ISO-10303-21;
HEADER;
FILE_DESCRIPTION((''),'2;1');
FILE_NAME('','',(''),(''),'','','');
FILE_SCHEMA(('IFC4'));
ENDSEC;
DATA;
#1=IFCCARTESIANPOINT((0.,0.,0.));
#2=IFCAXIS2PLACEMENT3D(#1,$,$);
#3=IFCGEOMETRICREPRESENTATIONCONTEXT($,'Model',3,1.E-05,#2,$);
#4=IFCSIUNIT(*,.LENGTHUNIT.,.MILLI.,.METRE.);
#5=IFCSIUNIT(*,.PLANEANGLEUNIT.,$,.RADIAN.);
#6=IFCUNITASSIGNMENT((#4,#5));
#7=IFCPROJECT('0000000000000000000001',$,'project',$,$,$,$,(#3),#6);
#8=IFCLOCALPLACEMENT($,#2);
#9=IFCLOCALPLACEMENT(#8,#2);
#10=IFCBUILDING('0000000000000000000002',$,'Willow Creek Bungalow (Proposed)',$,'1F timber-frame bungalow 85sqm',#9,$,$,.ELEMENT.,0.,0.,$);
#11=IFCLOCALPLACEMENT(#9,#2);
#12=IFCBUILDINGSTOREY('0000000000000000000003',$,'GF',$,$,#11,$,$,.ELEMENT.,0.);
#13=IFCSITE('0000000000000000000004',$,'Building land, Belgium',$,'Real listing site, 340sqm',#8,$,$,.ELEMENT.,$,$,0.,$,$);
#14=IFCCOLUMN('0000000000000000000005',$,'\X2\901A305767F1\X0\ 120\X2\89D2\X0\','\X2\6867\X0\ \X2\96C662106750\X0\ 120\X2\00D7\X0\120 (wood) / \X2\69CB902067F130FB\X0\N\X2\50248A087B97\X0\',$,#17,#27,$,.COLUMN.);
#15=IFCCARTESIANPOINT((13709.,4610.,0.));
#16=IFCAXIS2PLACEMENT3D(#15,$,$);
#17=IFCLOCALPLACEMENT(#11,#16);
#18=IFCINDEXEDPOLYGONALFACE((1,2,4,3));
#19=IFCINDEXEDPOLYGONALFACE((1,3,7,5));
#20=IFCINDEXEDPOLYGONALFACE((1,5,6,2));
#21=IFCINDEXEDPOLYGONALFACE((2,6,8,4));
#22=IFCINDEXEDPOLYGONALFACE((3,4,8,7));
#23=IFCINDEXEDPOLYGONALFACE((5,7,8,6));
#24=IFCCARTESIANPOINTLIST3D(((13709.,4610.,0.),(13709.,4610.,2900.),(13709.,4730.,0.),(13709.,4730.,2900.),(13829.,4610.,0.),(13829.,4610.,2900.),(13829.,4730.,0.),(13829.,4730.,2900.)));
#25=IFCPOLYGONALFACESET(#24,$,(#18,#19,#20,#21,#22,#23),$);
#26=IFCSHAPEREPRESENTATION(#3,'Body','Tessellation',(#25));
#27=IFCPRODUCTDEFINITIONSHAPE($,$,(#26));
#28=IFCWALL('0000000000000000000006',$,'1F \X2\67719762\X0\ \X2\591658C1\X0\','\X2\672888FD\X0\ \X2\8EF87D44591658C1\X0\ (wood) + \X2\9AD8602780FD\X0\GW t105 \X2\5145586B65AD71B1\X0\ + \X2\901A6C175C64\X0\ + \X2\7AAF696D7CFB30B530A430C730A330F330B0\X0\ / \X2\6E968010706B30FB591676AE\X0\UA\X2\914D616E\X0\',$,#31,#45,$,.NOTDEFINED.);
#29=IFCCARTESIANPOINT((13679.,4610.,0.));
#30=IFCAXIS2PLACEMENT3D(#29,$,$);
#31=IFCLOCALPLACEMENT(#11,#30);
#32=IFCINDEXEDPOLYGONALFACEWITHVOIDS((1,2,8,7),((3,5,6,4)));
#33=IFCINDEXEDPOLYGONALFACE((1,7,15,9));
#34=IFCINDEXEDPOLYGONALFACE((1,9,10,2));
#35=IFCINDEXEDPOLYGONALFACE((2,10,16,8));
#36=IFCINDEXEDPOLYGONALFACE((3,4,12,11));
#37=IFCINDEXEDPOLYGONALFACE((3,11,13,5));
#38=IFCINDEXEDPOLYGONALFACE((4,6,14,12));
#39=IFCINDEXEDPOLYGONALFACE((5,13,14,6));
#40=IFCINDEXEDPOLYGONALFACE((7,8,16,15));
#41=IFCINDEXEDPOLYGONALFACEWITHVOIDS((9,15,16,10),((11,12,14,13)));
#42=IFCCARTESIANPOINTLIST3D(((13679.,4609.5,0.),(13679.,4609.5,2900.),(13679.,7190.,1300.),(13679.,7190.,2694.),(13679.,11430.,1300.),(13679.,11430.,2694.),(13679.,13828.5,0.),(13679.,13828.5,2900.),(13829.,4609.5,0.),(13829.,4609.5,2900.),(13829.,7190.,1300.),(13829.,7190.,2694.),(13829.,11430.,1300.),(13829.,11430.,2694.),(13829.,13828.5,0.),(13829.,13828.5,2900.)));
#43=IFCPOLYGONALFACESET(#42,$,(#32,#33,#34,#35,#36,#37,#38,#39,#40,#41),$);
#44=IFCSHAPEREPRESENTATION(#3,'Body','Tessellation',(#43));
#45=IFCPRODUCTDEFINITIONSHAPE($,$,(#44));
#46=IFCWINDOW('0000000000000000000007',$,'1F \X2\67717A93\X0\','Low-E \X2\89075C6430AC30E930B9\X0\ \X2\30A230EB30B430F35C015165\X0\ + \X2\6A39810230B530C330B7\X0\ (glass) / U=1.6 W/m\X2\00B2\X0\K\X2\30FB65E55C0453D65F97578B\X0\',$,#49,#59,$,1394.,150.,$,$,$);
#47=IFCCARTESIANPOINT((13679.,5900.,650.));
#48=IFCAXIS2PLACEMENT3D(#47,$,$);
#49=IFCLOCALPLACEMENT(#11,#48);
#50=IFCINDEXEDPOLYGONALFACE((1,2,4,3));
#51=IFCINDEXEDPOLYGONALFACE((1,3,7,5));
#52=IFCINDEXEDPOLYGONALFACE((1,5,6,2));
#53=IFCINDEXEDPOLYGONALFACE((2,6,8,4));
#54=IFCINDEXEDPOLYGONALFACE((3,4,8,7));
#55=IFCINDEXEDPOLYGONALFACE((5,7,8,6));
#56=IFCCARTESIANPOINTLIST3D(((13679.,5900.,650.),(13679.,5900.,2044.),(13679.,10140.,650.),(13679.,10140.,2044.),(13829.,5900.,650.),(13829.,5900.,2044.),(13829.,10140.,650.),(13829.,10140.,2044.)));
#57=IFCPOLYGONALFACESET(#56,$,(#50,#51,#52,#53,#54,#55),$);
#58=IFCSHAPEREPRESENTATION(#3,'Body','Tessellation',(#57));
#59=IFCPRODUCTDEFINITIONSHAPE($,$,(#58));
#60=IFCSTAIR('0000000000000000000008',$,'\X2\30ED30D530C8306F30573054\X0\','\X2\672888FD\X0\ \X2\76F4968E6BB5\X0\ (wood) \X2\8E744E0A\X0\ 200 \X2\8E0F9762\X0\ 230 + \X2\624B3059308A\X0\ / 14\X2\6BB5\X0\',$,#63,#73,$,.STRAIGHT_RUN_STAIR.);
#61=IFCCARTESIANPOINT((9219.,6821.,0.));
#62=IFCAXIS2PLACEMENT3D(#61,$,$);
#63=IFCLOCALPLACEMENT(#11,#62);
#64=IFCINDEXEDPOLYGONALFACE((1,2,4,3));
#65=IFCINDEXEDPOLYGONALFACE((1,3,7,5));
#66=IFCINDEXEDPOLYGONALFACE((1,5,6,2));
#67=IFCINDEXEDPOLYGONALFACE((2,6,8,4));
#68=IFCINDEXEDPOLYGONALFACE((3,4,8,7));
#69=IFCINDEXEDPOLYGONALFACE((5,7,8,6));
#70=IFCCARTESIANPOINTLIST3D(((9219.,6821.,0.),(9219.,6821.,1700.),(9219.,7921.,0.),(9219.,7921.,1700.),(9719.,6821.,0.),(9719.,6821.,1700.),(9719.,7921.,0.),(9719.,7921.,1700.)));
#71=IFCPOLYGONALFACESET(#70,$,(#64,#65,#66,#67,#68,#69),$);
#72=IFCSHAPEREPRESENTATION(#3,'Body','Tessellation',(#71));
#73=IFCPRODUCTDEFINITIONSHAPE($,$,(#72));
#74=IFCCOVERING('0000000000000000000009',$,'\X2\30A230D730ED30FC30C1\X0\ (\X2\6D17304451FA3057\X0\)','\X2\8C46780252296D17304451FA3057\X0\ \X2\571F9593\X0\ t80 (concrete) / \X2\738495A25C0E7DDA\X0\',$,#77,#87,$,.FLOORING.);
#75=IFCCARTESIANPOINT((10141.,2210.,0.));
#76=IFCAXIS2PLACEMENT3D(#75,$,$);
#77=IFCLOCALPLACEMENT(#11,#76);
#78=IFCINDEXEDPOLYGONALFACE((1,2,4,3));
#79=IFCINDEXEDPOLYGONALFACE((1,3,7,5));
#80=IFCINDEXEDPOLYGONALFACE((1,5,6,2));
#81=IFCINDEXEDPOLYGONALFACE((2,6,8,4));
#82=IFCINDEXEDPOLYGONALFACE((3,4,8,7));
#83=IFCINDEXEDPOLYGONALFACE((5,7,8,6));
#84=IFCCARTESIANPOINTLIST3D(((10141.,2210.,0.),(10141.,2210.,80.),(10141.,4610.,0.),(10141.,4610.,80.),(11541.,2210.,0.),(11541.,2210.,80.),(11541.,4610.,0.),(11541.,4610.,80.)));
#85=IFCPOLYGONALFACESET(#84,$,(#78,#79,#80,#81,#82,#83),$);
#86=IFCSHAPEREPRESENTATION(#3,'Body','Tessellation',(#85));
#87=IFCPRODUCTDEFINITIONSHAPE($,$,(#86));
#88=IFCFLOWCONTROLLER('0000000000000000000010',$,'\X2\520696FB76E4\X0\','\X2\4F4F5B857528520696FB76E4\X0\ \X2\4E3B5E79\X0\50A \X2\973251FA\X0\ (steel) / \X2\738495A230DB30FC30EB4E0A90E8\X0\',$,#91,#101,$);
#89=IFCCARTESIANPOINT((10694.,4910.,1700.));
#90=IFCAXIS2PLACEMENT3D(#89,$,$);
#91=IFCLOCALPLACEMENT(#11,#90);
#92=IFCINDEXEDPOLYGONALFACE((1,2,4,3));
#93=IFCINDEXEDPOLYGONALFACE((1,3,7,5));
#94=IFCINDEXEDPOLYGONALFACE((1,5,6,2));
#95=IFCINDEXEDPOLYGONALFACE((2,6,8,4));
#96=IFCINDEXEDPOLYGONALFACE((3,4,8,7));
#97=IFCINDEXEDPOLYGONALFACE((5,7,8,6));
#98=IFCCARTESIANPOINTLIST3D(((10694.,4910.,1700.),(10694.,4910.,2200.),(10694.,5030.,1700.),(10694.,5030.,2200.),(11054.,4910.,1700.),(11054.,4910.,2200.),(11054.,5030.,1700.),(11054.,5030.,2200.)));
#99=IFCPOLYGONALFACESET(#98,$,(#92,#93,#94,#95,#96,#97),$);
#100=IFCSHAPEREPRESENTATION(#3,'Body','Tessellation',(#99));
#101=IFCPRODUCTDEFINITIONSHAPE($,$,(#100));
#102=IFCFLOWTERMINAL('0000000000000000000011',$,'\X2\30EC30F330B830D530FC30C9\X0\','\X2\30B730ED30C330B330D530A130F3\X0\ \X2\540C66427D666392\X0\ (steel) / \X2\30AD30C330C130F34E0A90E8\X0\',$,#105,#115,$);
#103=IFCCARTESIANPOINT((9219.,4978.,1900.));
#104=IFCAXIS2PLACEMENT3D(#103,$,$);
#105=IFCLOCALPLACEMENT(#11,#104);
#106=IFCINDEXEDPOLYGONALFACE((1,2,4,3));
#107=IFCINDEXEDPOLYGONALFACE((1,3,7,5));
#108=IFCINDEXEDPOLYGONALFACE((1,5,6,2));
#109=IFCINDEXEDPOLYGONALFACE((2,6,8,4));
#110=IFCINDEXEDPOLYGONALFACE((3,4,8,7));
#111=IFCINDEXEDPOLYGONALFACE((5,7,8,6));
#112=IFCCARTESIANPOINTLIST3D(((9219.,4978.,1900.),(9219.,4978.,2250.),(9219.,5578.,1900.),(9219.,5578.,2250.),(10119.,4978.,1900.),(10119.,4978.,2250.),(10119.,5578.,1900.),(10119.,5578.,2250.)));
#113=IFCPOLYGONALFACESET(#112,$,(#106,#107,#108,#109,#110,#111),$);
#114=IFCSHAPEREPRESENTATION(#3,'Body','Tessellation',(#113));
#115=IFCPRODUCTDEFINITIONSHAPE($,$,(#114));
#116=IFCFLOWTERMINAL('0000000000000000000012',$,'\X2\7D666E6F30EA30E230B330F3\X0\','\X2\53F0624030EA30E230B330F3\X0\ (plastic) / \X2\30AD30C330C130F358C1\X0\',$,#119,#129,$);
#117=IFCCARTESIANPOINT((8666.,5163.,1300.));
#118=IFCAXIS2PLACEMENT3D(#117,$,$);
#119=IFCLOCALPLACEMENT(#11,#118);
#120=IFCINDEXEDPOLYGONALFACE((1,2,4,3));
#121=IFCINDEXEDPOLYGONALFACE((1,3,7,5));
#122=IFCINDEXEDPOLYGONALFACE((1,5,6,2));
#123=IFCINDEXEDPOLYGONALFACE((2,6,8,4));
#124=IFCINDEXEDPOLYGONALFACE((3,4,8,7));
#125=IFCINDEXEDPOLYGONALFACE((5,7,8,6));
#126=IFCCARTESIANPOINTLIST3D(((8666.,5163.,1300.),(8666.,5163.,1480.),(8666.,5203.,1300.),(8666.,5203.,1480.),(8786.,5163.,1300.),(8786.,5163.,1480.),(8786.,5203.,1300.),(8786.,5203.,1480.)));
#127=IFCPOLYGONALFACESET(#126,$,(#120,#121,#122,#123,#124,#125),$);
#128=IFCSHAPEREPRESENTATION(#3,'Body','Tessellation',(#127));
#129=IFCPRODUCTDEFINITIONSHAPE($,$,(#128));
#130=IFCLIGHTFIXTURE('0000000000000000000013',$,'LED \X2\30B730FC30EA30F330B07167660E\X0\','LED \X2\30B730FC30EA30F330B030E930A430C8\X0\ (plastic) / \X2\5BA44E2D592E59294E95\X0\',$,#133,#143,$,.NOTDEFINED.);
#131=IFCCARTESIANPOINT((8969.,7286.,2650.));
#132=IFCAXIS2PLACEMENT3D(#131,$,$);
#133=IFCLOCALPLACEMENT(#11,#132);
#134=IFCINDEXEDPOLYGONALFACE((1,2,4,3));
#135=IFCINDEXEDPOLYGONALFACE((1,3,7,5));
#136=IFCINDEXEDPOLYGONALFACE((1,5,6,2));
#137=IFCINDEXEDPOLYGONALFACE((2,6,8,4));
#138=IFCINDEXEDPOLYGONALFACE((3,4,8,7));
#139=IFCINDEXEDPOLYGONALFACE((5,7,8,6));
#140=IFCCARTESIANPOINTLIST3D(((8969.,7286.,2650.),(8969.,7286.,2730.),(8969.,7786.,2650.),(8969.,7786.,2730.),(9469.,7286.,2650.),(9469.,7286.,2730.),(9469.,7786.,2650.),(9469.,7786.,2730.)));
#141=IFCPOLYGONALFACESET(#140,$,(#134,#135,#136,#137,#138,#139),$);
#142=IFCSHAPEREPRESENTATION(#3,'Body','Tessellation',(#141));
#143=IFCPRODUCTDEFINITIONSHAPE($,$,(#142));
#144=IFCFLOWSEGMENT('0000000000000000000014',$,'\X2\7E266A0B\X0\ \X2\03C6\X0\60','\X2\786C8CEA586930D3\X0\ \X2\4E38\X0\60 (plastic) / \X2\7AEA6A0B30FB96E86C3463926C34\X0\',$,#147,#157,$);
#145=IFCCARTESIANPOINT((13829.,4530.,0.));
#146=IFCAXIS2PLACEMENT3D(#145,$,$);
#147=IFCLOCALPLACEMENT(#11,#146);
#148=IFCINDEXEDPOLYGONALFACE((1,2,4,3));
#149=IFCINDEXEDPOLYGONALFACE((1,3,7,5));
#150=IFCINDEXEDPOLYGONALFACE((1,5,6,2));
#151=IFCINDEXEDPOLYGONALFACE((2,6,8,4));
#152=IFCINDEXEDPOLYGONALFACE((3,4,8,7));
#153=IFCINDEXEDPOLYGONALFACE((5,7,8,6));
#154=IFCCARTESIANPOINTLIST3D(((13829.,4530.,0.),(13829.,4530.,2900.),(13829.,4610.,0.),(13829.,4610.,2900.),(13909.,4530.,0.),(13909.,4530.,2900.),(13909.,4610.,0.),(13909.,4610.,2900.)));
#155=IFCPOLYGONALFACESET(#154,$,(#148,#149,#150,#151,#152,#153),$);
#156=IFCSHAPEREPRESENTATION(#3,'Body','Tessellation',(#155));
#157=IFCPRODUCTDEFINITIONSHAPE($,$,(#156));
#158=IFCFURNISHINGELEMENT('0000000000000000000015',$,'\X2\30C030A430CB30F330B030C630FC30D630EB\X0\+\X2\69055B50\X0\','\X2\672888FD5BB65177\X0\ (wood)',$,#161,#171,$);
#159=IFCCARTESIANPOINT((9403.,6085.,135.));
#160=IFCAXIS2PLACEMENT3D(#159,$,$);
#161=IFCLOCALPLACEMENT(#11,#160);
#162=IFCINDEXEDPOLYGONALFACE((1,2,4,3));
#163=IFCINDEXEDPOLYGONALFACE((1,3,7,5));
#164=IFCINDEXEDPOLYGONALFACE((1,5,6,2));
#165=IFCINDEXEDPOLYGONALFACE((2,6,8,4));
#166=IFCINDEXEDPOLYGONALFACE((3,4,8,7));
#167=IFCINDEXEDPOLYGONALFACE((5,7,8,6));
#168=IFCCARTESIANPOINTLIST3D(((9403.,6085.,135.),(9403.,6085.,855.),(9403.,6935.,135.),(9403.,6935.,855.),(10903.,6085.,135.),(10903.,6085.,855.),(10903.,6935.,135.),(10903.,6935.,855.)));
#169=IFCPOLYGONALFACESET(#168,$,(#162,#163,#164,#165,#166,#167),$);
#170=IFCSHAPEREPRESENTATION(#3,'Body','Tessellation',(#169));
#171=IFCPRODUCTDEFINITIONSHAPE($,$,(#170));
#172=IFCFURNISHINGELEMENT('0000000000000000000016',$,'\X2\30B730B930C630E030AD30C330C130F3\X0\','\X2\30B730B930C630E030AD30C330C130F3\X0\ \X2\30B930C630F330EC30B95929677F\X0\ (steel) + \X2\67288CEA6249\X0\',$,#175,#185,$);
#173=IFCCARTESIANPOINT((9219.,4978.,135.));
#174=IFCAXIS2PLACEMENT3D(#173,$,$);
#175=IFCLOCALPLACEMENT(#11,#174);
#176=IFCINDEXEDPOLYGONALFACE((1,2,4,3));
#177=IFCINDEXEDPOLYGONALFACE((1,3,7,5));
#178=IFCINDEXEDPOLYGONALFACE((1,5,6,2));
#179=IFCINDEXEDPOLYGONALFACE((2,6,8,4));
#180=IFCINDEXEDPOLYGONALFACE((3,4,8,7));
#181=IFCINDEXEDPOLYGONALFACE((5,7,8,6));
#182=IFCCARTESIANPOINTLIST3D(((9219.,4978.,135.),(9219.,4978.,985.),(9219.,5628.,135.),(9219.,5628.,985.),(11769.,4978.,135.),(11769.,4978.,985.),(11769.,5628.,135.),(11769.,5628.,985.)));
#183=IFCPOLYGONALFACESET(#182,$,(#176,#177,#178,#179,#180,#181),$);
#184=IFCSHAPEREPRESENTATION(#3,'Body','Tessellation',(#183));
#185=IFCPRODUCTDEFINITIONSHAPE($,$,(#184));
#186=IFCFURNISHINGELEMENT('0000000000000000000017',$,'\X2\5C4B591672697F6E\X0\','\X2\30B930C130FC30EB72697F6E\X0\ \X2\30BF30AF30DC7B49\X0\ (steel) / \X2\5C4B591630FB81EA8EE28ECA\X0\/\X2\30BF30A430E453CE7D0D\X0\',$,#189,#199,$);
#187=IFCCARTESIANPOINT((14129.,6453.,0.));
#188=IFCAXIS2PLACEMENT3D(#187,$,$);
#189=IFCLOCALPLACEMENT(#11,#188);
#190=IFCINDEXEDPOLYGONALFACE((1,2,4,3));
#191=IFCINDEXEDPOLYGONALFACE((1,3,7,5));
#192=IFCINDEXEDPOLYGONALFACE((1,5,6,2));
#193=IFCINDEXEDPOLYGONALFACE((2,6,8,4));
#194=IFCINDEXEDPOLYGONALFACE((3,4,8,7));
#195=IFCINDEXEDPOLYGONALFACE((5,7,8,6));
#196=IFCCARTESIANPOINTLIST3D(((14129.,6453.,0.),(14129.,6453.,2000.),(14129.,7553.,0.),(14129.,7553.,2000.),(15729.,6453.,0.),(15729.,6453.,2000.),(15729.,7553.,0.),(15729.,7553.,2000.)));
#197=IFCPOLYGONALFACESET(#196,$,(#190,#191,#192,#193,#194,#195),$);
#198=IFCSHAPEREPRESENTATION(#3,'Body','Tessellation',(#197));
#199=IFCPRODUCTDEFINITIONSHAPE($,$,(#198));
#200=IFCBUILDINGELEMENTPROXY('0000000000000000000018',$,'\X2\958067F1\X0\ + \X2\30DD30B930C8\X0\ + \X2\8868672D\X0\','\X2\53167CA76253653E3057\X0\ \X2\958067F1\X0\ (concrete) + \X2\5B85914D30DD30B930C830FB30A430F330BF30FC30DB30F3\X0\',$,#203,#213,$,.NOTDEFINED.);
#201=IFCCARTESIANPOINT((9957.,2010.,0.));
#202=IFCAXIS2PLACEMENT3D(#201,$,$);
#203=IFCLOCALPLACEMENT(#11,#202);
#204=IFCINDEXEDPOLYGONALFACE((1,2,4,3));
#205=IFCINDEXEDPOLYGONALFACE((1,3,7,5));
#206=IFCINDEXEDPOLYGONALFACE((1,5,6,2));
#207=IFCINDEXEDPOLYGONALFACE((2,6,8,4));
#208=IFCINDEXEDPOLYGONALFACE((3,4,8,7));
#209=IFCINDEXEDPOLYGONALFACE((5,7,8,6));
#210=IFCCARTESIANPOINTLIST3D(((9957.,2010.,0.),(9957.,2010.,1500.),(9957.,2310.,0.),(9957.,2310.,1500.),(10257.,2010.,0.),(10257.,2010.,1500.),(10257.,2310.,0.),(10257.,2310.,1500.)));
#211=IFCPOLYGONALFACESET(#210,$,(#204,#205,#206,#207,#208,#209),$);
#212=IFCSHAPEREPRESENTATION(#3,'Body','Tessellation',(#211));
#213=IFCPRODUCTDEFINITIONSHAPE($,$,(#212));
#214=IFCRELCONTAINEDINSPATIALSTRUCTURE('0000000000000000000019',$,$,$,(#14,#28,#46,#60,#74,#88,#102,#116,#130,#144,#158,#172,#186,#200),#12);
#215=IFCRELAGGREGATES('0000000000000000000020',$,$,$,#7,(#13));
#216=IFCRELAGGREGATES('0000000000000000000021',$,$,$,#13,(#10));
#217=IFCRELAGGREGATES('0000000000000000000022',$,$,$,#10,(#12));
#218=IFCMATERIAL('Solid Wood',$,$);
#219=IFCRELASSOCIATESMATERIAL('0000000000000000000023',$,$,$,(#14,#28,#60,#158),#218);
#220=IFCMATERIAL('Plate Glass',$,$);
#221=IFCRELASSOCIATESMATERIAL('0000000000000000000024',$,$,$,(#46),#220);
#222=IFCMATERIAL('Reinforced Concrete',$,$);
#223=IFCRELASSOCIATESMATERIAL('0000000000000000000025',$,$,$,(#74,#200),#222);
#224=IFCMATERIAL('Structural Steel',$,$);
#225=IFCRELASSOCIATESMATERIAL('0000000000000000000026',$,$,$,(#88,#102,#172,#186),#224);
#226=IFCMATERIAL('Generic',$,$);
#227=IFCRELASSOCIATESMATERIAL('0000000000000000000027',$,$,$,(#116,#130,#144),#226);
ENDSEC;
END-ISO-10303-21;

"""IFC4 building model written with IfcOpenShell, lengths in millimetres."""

from ifc_helpers import new_model, si_unit, frame, frame_2d, origin, place, context, project, spatial, rectangle, extrude, material, element, fill, save


model = new_model("IFC4")

# Units and contexts
model_context = context("Model", 3, precision=1e-05, world=origin())
ifc_project = project(units=[si_unit("LENGTHUNIT", "METRE", prefix="MILLI"), si_unit("PLANEANGLEUNIT", "RADIAN")], contexts=[model_context])

# Site, building, storey
site_placement = place(None, origin())
site = spatial("IfcSite", under=ifc_project, at=site_placement, Name="Building land, Belgium", ObjectType="Real listing site, 340sqm", CompositionType="ELEMENT", RefElevation=0.0)
building_placement = place(site_placement, origin())
building = spatial("IfcBuilding", under=site, at=building_placement, Name="Willow Creek Bungalow (Proposed)", ObjectType="1F timber-frame bungalow 85sqm", CompositionType="ELEMENT", ElevationOfRefHeight=0.0, ElevationOfTerrain=0.0)
storey_placement = place(building_placement, origin())
storey = spatial("IfcBuildingStorey", under=building, at=storey_placement, Name="GF", CompositionType="ELEMENT", Elevation=0.0)

# Column
ifc_material_1 = material(Name="Solid Wood")
column_1_placement = place(storey_placement, frame((13709.0, 4610.0, 0.0)))
element("IfcColumn", 1, at=column_1_placement, inside=storey, material=ifc_material_1, Name="通し柱 120角", Description="桧 集成材 120×120 (wood) / 構造柱・N値計算", PredefinedType="COLUMN", context=model_context, shape_type="SweptSolid", body=[
    extrude(rectangle(XDim=120.0, YDim=120.0, at=frame_2d((60.0, 60.0))), frame((13709.0, 4610.0, 0.0)), (0.0, 0.0, 1.0), 2900.0),
])

# Wall, opening, window
wall_1_placement = place(storey_placement, frame((13679.0, 4610.0, 0.0)))
wall_1 = element("IfcWall", 2, at=wall_1_placement, inside=storey, material=ifc_material_1, Name="1F 東面 外壁", Description="木製 軸組外壁 (wood) + 高性能GW t105 充填断熱 + 通気層 + 窯業系サイディング / 準耐火・外皮UA配慮", PredefinedType="NOTDEFINED", context=model_context, shape_type="SweptSolid", body=[
    extrude(rectangle(XDim=150.0, YDim=9219.0, at=frame_2d((75.0, 4609.0))), frame((13679.0, 4610.0, 0.0)), (0.0, 0.0, 1.0), 2900.0),
])
opening_placement = place(storey_placement, frame((13679.0, 5900.0, 650.0)))
opening = element("IfcOpeningElement", 3, at=opening_placement, cuts=wall_1, PredefinedType="NOTDEFINED", context=model_context, shape_type="SweptSolid", body=[
    extrude(rectangle(XDim=150.0, YDim=4240.0, at=frame_2d((75.0, 2120.0))), frame((13679.0, 5900.0, 650.0)), (0.0, 0.0, 1.0), 1394.0),
])
ifc_material_2 = material(Name="Plate Glass")
window_placement = place(storey_placement, frame((13679.0, 5900.0, 650.0)))
window = element("IfcWindow", 4, at=window_placement, inside=storey, material=ifc_material_2, Name="1F 東窓", Description="Low-E 複層ガラス アルゴン封入 + 樹脂サッシ (glass) / U=1.6 W/m²K・日射取得型", OverallHeight=1394.0, OverallWidth=150.0, context=model_context, shape_type="SweptSolid", body=[
    extrude(rectangle(XDim=150.0, YDim=4240.0, at=frame_2d((75.0, 2120.0))), frame((13679.0, 5900.0, 650.0)), (0.0, 0.0, 1.0), 1394.0),
])
fill(opening, window)

# Stair
stair_placement = place(storey_placement, frame((9219.0, 6821.0, 0.0)))
element("IfcStair", 5, at=stair_placement, inside=storey, material=ifc_material_1, Name="ロフトはしご", Description="木製 直階段 (wood) 蹴上 200 踏面 230 + 手すり / 14段", PredefinedType="STRAIGHT_RUN_STAIR", context=model_context, shape_type="SweptSolid", body=[
    extrude(rectangle(XDim=500.0, YDim=1100.0, at=frame_2d((250.0, 550.0))), frame((9219.0, 6821.0, 0.0)), (0.0, 0.0, 1.0), 1700.0),
])

# Covering
ifc_material_3 = material(Name="Reinforced Concrete")
covering_placement = place(storey_placement, frame((10141.0, 2210.0, 0.0)))
element("IfcCovering", 6, at=covering_placement, inside=storey, material=ifc_material_3, Name="アプローチ (洗い出し)", Description="豆砂利洗い出し 土間 t80 (concrete) / 玄関導線", PredefinedType="FLOORING", context=model_context, shape_type="SweptSolid", body=[
    extrude(rectangle(XDim=1400.0, YDim=2400.0, at=frame_2d((700.0, 1200.0))), frame((10141.0, 2210.0, 0.0)), (0.0, 0.0, 1.0), 80.0),
])

# Flow controller
ifc_material_4 = material(Name="Structural Steel")
flow_controller_placement = place(storey_placement, frame((10694.0, 4910.0, 1700.0)))
element("IfcFlowController", 7, at=flow_controller_placement, inside=storey, material=ifc_material_4, Name="分電盤", Description="住宅用分電盤 主幹50A 露出 (steel) / 玄関ホール上部", context=model_context, shape_type="SweptSolid", body=[
    extrude(rectangle(XDim=360.0, YDim=120.0, at=frame_2d((180.0, 60.0))), frame((10694.0, 4910.0, 1700.0)), (0.0, 0.0, 1.0), 500.0),
])

# Flow terminals
flow_terminal_1_placement = place(storey_placement, frame((9219.0, 4978.0, 1900.0)))
element("IfcFlowTerminal", 8, at=flow_terminal_1_placement, inside=storey, material=ifc_material_4, Name="レンジフード", Description="シロッコファン 同時給排 (steel) / キッチン上部", context=model_context, shape_type="SweptSolid", body=[
    extrude(rectangle(XDim=900.0, YDim=600.0, at=frame_2d((450.0, 300.0))), frame((9219.0, 4978.0, 1900.0)), (0.0, 0.0, 1.0), 350.0),
])
ifc_material_5 = material(Name="Generic")
flow_terminal_2_placement = place(storey_placement, frame((8666.0, 5163.0, 1300.0)))
element("IfcFlowTerminal", 9, at=flow_terminal_2_placement, inside=storey, material=ifc_material_5, Name="給湯リモコン", Description="台所リモコン (plastic) / キッチン壁", context=model_context, shape_type="SweptSolid", body=[
    extrude(rectangle(XDim=120.0, YDim=40.0, at=frame_2d((60.0, 20.0))), frame((8666.0, 5163.0, 1300.0)), (0.0, 0.0, 1.0), 180.0),
])

# Light fixture
light_fixture_placement = place(storey_placement, frame((8969.0, 7286.0, 2650.0)))
element("IfcLightFixture", 10, at=light_fixture_placement, inside=storey, material=ifc_material_5, Name="LED シーリング照明", Description="LED シーリングライト (plastic) / 室中央天井", PredefinedType="NOTDEFINED", context=model_context, shape_type="SweptSolid", body=[
    extrude(rectangle(XDim=500.0, YDim=500.0, at=frame_2d((250.0, 250.0))), frame((8969.0, 7286.0, 2650.0)), (0.0, 0.0, 1.0), 80.0),
])

# Flow segment
flow_segment_placement = place(storey_placement, frame((13829.0, 4530.0, 0.0)))
element("IfcFlowSegment", 11, at=flow_segment_placement, inside=storey, material=ifc_material_5, Name="縦樋 φ60", Description="硬質塩ビ 丸60 (plastic) / 竪樋・雨水排水", context=model_context, shape_type="SweptSolid", body=[
    extrude(rectangle(XDim=80.0, YDim=80.0, at=frame_2d((40.0, 40.0))), frame((13829.0, 4530.0, 0.0)), (0.0, 0.0, 1.0), 2900.0),
])

# Furnishing elements
furnishing_1_placement = place(storey_placement, frame((9403.0, 6085.0, 135.0)))
element("IfcFurnishingElement", 12, at=furnishing_1_placement, inside=storey, material=ifc_material_1, Name="ダイニングテーブル+椅子", Description="木製家具 (wood)", context=model_context, shape_type="SweptSolid", body=[
    extrude(rectangle(XDim=1500.0, YDim=850.0, at=frame_2d((750.0, 425.0))), frame((9403.0, 6085.0, 135.0)), (0.0, 0.0, 1.0), 720.0),
])
furnishing_2_placement = place(storey_placement, frame((9219.0, 4978.0, 135.0)))
element("IfcFurnishingElement", 13, at=furnishing_2_placement, inside=storey, material=ifc_material_4, Name="システムキッチン", Description="システムキッチン ステンレス天板 (steel) + 木質扉", context=model_context, shape_type="SweptSolid", body=[
    extrude(rectangle(XDim=2550.0, YDim=650.0, at=frame_2d((1275.0, 325.0))), frame((9219.0, 4978.0, 135.0)), (0.0, 0.0, 1.0), 850.0),
])
furnishing_3_placement = place(storey_placement, frame((14129.0, 6453.0, 0.0)))
element("IfcFurnishingElement", 14, at=furnishing_3_placement, inside=storey, material=ifc_material_4, Name="屋外物置", Description="スチール物置 タクボ等 (steel) / 屋外・自転車/タイヤ収納", context=model_context, shape_type="SweptSolid", body=[
    extrude(rectangle(XDim=1600.0, YDim=1100.0, at=frame_2d((800.0, 550.0))), frame((14129.0, 6453.0, 0.0)), (0.0, 0.0, 1.0), 2000.0),
])

# Building element proxy
proxy_placement = place(storey_placement, frame((9957.0, 2010.0, 0.0)))
element("IfcBuildingElementProxy", 15, at=proxy_placement, inside=storey, material=ifc_material_3, Name="門柱 + ポスト + 表札", Description="化粧打放し 門柱 (concrete) + 宅配ポスト・インターホン", PredefinedType="NOTDEFINED", context=model_context, shape_type="SweptSolid", body=[
    extrude(rectangle(XDim=300.0, YDim=300.0, at=frame_2d((150.0, 150.0))), frame((9957.0, 2010.0, 0.0)), (0.0, 0.0, 1.0), 1500.0),
])

save(model, "model.ifc")
